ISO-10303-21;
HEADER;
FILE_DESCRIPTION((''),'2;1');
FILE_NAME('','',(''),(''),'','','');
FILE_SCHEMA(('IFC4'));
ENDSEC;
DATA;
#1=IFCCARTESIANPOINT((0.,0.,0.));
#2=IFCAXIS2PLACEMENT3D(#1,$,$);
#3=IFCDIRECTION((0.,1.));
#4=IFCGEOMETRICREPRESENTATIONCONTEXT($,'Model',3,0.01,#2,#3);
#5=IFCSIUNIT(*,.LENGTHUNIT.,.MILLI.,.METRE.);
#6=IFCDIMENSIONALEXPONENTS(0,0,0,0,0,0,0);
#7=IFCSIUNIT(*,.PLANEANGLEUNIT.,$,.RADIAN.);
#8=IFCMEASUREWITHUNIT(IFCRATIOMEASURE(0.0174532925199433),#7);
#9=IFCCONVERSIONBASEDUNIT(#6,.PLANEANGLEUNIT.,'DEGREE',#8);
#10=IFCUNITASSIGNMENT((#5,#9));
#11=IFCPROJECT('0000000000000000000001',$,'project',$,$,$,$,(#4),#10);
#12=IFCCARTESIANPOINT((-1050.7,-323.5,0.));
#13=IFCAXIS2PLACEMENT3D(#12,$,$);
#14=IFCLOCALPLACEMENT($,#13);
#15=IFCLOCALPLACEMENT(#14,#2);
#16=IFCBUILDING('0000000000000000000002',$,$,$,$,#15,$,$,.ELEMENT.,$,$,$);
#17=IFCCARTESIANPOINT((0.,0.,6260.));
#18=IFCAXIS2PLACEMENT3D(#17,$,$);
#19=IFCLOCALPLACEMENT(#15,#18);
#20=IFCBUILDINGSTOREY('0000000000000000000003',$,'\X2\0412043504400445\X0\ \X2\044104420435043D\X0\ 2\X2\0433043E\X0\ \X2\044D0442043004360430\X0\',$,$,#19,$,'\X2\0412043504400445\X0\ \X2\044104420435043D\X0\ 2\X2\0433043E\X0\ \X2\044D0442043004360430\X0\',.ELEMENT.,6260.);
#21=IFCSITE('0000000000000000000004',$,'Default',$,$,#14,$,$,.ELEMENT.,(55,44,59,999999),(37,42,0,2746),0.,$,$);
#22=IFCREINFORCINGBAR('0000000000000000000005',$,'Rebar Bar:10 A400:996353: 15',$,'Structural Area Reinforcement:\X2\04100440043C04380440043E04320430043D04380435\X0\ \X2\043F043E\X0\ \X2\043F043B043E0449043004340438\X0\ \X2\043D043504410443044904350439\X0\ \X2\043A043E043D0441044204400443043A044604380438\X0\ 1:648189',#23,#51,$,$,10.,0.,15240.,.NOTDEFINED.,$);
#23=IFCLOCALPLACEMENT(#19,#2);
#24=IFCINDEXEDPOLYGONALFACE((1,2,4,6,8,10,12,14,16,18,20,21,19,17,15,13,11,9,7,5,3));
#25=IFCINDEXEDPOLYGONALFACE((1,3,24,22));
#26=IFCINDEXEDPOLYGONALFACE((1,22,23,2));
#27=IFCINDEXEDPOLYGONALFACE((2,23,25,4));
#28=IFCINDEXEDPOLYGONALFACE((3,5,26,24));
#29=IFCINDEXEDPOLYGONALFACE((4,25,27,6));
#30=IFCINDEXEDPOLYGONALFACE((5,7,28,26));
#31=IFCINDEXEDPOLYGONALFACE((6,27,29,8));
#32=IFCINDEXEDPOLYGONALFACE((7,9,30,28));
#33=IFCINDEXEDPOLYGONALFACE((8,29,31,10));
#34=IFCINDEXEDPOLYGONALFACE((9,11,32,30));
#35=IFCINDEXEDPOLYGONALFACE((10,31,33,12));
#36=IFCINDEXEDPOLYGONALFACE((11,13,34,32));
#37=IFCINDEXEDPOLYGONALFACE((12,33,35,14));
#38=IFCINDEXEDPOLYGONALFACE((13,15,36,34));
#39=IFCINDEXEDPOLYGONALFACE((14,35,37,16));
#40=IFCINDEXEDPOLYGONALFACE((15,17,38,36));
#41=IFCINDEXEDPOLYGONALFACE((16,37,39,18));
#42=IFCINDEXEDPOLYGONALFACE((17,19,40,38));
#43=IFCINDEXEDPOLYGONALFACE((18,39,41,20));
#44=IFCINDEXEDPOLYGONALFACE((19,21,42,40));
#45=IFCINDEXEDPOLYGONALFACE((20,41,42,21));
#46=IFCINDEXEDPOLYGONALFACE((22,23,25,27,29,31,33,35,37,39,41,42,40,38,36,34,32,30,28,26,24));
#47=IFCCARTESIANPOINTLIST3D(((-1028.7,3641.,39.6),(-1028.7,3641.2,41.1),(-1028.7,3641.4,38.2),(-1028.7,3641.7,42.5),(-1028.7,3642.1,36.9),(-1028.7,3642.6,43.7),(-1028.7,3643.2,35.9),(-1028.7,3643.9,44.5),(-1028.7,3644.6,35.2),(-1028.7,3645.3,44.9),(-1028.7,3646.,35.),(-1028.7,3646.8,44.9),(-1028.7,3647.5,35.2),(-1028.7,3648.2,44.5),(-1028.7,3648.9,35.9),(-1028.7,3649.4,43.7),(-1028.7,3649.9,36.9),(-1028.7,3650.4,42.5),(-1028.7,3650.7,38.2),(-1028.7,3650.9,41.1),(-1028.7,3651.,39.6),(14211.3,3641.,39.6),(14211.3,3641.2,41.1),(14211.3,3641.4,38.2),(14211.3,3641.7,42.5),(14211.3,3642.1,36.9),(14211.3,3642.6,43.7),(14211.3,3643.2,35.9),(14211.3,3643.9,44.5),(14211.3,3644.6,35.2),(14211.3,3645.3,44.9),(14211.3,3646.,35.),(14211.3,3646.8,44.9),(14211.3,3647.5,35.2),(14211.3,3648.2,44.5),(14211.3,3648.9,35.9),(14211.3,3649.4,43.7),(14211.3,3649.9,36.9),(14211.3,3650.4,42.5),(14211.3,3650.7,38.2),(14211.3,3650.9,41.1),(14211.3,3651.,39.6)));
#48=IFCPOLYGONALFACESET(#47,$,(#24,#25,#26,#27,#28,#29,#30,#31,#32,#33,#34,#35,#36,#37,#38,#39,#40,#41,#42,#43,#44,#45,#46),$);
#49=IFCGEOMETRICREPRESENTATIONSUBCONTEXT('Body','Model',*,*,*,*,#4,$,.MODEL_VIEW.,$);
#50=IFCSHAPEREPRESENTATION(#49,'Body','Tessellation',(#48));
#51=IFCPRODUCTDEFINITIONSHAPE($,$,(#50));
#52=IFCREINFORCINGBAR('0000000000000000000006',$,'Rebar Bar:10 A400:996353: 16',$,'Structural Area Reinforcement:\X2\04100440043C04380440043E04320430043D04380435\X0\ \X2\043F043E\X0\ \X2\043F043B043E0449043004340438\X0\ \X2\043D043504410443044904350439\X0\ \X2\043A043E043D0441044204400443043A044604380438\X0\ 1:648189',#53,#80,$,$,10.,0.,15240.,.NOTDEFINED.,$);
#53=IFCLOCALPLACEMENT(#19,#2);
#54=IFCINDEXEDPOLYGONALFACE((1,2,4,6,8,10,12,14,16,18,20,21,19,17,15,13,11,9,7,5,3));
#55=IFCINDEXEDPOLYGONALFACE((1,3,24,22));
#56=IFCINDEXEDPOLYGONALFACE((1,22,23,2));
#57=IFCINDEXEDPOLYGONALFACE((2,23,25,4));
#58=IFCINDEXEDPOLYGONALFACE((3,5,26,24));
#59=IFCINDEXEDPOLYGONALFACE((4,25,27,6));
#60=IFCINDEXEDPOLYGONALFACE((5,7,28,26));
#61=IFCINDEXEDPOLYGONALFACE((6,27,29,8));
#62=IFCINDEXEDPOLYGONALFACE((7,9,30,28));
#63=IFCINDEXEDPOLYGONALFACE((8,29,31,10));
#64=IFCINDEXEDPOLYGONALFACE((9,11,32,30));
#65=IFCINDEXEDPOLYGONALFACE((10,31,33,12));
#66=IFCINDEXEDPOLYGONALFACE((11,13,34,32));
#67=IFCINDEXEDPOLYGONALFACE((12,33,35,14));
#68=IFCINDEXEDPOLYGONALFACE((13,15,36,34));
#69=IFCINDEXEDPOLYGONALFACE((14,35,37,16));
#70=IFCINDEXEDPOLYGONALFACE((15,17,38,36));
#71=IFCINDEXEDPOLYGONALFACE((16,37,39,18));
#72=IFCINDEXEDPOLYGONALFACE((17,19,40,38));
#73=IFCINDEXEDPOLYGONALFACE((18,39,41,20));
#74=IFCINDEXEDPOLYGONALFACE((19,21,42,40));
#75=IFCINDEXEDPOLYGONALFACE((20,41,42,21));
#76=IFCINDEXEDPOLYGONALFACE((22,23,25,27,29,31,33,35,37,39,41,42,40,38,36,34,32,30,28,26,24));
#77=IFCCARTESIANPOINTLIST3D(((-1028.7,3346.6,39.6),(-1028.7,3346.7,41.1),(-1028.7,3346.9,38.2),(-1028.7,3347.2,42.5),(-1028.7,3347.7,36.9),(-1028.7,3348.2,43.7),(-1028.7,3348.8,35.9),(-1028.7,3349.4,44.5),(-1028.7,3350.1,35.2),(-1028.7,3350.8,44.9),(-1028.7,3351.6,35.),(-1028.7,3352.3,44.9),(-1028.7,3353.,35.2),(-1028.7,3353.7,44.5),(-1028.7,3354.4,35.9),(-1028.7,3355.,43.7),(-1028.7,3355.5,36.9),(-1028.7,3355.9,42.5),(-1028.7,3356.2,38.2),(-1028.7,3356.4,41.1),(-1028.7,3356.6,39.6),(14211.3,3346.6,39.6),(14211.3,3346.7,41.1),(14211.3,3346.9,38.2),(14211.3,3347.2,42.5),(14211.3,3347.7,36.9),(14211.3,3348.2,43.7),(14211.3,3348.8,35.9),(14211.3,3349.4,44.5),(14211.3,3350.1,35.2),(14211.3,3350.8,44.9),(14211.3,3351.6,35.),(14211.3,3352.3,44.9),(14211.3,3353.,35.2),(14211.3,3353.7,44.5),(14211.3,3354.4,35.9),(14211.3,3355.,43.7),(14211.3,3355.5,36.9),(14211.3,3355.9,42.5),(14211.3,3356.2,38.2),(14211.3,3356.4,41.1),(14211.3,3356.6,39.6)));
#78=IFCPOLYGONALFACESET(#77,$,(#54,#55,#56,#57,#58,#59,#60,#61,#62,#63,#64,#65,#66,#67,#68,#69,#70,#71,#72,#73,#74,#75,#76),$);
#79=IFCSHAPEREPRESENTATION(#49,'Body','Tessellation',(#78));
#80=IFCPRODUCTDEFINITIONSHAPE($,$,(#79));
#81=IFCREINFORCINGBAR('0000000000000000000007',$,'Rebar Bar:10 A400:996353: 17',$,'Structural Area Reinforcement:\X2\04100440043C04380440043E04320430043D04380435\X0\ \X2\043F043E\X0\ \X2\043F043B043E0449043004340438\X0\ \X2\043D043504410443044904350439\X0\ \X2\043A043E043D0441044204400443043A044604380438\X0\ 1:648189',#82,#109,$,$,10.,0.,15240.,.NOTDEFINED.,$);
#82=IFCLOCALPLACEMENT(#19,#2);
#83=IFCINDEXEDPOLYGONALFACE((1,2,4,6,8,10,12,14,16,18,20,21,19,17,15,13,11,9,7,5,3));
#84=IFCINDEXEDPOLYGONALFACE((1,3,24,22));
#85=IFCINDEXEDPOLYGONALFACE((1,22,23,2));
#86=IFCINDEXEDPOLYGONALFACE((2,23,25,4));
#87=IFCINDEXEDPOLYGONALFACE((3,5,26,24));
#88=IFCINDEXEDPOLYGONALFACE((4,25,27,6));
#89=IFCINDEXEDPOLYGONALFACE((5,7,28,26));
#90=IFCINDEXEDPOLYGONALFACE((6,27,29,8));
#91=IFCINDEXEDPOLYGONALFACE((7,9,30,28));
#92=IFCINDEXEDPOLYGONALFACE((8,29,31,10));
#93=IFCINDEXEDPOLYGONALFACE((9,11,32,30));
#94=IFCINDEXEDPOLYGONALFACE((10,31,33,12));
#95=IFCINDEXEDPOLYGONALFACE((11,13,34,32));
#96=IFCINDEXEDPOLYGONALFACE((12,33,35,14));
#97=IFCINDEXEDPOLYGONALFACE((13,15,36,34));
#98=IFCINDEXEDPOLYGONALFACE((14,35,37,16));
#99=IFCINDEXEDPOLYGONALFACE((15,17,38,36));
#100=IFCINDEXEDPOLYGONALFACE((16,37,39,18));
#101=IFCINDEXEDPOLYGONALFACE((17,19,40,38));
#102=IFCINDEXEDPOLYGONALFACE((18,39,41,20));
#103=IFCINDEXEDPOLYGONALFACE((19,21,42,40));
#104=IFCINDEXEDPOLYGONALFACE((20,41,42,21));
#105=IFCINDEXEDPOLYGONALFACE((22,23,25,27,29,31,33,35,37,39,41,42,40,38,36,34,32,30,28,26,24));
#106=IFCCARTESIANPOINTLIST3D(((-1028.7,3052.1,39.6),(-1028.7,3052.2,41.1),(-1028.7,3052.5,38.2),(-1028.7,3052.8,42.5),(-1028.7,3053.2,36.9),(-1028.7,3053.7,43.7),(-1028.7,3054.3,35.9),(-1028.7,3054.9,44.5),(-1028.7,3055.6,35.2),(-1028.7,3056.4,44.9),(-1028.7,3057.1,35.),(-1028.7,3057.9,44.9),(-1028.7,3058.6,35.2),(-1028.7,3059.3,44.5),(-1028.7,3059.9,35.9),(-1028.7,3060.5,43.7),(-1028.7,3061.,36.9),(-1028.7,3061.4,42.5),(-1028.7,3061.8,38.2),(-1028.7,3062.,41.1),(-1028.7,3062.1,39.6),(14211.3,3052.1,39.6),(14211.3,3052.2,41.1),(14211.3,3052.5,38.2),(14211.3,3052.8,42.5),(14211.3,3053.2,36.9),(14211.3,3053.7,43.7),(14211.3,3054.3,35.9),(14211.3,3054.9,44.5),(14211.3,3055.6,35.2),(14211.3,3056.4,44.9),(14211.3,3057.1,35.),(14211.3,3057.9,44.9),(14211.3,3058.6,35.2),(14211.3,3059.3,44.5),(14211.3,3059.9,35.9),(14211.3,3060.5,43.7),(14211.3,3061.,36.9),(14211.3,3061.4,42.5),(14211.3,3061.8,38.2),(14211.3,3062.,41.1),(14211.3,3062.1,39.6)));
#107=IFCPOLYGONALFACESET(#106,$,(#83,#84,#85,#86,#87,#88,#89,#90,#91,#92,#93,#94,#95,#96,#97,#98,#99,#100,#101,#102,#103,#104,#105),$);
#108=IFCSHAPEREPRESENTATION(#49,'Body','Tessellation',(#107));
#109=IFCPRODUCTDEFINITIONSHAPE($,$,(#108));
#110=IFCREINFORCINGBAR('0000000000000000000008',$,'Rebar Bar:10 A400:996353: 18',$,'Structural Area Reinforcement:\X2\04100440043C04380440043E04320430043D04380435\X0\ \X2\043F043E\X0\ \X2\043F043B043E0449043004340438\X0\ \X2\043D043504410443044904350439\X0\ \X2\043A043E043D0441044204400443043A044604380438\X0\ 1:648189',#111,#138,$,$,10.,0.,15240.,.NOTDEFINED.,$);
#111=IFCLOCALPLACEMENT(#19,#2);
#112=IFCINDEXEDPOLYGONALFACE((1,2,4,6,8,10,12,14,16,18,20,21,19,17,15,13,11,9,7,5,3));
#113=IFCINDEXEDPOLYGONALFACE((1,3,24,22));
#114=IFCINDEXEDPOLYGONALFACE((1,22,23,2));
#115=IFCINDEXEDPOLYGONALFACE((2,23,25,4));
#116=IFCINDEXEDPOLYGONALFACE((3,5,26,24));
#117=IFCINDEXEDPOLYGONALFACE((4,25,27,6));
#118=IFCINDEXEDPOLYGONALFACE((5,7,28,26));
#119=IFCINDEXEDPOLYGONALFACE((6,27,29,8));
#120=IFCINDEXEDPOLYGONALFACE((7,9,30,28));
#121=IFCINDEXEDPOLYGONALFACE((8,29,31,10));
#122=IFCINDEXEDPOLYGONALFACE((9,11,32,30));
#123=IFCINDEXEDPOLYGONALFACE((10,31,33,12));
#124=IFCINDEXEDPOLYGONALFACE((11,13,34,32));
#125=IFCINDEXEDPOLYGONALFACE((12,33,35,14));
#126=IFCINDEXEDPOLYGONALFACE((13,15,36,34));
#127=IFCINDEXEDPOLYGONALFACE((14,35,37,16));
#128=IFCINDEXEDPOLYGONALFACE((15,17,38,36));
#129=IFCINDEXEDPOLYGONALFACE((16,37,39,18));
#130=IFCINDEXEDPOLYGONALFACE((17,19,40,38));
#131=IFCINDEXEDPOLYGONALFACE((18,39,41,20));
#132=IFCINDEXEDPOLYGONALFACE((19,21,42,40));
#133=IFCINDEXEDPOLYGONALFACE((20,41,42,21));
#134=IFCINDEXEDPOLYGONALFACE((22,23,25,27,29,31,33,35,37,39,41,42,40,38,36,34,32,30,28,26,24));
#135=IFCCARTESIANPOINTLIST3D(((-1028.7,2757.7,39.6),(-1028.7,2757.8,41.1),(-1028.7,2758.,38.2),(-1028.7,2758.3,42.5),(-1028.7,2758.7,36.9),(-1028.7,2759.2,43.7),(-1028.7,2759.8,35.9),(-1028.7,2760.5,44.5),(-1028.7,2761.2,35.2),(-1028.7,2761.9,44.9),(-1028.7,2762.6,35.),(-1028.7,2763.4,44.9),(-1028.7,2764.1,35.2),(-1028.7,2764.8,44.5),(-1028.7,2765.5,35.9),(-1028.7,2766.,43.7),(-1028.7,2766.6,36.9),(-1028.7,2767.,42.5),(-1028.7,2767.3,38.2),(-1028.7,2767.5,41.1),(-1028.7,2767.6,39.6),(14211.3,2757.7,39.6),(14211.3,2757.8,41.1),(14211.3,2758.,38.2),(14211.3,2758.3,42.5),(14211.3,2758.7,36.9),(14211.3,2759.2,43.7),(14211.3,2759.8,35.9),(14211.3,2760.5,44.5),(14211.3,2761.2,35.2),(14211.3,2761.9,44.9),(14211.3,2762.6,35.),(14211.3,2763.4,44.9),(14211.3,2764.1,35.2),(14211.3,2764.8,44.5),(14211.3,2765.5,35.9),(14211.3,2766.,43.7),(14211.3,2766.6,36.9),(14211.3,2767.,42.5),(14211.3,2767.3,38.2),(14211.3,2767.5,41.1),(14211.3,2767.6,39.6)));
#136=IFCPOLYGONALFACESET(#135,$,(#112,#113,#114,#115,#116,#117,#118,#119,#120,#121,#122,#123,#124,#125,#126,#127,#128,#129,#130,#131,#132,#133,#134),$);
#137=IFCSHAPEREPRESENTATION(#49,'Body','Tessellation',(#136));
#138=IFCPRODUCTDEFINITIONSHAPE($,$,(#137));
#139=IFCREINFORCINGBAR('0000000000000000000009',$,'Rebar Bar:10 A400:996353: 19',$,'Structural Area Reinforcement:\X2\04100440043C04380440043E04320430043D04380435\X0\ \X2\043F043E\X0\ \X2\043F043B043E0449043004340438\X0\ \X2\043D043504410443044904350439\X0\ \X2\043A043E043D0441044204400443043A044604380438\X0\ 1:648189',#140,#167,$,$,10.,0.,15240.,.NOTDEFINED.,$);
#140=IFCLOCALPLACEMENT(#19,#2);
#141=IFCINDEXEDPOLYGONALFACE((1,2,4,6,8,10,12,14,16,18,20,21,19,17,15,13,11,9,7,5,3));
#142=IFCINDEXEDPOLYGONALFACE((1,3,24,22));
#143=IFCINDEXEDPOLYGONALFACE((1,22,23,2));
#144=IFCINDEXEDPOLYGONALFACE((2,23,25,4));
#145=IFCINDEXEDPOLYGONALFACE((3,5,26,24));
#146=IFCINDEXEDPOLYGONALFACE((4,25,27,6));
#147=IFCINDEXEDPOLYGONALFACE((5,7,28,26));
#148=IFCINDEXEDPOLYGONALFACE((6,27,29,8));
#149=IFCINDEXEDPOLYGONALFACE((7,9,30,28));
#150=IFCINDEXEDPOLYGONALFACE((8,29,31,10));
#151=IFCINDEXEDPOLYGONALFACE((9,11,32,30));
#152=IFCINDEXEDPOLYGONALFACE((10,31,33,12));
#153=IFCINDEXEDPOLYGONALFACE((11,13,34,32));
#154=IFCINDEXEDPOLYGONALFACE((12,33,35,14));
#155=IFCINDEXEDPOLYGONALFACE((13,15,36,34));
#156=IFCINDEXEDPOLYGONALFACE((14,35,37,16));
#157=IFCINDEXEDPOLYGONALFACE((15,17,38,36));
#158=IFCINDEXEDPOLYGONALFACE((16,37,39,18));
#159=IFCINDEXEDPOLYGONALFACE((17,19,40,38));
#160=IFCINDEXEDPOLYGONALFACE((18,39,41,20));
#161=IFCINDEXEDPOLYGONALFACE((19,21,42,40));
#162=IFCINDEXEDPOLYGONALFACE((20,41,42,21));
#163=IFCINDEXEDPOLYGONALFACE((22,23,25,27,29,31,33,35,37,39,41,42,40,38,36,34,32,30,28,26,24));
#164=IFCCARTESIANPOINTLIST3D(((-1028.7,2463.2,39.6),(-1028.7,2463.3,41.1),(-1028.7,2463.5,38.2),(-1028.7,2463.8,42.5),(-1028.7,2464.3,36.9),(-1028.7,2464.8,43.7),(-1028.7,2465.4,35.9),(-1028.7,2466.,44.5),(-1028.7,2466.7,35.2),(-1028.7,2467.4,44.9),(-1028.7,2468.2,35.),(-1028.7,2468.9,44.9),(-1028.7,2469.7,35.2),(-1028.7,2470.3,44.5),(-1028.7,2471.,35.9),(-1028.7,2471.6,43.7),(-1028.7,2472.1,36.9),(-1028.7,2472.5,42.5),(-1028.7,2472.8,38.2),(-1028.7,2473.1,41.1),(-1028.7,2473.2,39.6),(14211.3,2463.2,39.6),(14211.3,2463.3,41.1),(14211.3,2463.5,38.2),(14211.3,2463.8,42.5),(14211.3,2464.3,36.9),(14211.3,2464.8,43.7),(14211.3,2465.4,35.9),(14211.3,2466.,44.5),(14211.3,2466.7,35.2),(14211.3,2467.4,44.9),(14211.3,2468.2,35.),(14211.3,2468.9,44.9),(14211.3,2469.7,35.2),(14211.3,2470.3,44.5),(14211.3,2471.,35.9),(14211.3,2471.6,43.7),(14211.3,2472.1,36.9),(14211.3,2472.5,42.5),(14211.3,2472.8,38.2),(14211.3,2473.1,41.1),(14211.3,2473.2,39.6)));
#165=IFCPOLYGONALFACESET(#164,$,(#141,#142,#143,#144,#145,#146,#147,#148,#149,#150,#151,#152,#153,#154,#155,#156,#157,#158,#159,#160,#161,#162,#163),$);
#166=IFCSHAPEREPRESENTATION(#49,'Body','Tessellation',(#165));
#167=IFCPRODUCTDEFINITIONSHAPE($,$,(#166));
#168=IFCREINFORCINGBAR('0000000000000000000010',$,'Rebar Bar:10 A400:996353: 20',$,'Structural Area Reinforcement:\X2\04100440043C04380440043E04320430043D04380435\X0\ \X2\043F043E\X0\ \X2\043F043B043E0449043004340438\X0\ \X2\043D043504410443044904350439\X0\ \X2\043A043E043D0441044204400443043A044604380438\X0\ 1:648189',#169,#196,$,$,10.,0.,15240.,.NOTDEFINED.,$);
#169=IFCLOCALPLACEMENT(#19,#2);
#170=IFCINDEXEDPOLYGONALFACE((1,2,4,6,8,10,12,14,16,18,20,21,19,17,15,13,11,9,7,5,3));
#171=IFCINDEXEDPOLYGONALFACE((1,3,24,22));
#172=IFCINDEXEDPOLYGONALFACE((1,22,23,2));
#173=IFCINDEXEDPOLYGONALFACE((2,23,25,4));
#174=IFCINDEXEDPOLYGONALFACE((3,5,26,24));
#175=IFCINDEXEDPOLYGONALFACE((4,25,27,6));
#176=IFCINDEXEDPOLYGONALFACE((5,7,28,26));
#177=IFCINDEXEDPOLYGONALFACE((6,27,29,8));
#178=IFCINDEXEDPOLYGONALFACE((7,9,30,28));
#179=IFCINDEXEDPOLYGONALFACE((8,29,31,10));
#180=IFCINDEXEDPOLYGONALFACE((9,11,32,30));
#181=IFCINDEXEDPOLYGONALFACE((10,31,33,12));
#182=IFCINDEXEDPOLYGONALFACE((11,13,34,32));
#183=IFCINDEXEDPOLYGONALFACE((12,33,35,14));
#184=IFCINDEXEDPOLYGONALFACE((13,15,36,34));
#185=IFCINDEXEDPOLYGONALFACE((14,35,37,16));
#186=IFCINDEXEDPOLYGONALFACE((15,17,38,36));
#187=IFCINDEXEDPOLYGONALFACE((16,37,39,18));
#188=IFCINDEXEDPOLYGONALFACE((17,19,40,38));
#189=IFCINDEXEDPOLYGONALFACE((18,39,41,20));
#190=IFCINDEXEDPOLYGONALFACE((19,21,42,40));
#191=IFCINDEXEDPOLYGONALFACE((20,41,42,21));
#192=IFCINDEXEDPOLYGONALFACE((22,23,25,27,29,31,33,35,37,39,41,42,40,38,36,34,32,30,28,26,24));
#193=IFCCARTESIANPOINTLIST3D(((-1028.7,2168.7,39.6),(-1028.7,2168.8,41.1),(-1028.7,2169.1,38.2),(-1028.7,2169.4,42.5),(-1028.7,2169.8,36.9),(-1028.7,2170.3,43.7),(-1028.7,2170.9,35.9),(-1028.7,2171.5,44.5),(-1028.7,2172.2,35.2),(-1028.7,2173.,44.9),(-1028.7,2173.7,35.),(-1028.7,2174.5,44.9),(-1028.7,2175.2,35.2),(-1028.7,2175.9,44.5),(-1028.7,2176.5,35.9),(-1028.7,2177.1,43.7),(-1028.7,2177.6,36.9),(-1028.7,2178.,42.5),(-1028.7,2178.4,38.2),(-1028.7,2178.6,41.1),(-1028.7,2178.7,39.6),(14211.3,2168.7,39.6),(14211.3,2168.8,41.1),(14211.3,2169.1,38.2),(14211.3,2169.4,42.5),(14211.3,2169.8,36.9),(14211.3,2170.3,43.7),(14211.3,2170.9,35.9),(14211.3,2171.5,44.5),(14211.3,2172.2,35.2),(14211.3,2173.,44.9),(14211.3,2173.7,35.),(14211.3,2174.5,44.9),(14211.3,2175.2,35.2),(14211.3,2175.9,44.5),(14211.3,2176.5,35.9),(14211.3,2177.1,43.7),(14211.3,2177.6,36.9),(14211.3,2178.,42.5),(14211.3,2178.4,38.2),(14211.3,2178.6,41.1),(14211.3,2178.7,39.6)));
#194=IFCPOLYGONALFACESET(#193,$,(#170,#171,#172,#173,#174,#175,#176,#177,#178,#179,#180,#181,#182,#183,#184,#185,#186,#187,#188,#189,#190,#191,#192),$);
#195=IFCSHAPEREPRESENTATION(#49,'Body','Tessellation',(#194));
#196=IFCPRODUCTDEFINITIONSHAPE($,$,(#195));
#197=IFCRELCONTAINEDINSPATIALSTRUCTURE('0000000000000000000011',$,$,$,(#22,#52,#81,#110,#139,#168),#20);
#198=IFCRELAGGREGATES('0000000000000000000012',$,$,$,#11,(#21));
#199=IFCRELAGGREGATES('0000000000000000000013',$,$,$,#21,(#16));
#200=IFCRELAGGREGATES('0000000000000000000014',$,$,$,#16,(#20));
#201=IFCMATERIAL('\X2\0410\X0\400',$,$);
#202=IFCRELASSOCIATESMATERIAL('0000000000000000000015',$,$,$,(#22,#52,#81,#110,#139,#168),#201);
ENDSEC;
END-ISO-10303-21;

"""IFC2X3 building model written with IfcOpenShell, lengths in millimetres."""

from ifc_helpers import new_model, entity, si_unit, converted_unit, direction, frame, origin, place, context, subcontext, project, spatial, material, element, save


model = new_model("IFC2X3")

# Units and contexts
model_context = context("Model", 3, precision=0.01, world=origin(), true_north=direction((0.0, 1.0)))
body_context = subcontext(model_context, "Body", "Model", "MODEL_VIEW")
ifc_project = project(units=[si_unit("LENGTHUNIT", "METRE", prefix="MILLI"), converted_unit("PLANEANGLEUNIT", "DEGREE", entity("IfcRatioMeasure", 0.0174532925199433), si_unit("PLANEANGLEUNIT", "RADIAN"), dimensions=[0, 0, 0, 0, 0, 0, 0])], contexts=[model_context])

# Site, building, storey
site_placement = place(None, frame((-1050.7, -323.5, 0.0)))
site = spatial("IfcSite", under=ifc_project, at=site_placement, Name="Default", CompositionType="ELEMENT", RefLatitude=(55, 44, 59, 999999), RefLongitude=(37, 42, 0, 2746), RefElevation=0.0)
building_placement = place(site_placement, origin())
building = spatial("IfcBuilding", under=site, at=building_placement, CompositionType="ELEMENT")
storey_placement = place(building_placement, frame((0.0, 0.0, 6260.0)))
storey = spatial("IfcBuildingStorey", under=building, at=storey_placement, Name="Верх стен 2го этажа", LongName="Верх стен 2го этажа", CompositionType="ELEMENT", Elevation=6260.0)

# Reinforcing bars
ifc_material = material(Name="А400")
reinforcing_bar_1_placement = place(storey_placement, origin())
element("IfcReinforcingBar", 1, at=reinforcing_bar_1_placement, inside=storey, material=ifc_material, Name="Rebar Bar:10 A400:996353: 15", ObjectType="Structural Area Reinforcement:Армирование по площади несущей конструкции 1:648189", BarLength=15240.0, BarRole="NOTDEFINED", CrossSectionArea=0.0, NominalDiameter=10.0, context=body_context, shape_type="AdvancedSweptSolid", body=[
    entity("IfcSweptDiskSolid", entity("IfcCompositeCurve", [entity("IfcCompositeCurveSegment", "CONTINUOUS", True, entity("IfcPolyline", [entity("IfcCartesianPoint", [14211.3, 3646.0, 40.0]), entity("IfcCartesianPoint", [-1028.7, 3646.0, 40.0])]))], False), 5.0, None, 0.0, 1.0),
])
reinforcing_bar_2_placement = place(storey_placement, origin())
element("IfcReinforcingBar", 2, at=reinforcing_bar_2_placement, inside=storey, material=ifc_material, Name="Rebar Bar:10 A400:996353: 16", ObjectType="Structural Area Reinforcement:Армирование по площади несущей конструкции 1:648189", BarLength=15240.0, BarRole="NOTDEFINED", CrossSectionArea=0.0, NominalDiameter=10.0, context=body_context, shape_type="AdvancedSweptSolid", body=[
    entity("IfcSweptDiskSolid", entity("IfcCompositeCurve", [entity("IfcCompositeCurveSegment", "CONTINUOUS", True, entity("IfcPolyline", [entity("IfcCartesianPoint", [14211.3, 3351.6, 40.0]), entity("IfcCartesianPoint", [-1028.7, 3351.6, 40.0])]))], False), 5.0, None, 0.0, 1.0),
])
reinforcing_bar_3_placement = place(storey_placement, origin())
element("IfcReinforcingBar", 3, at=reinforcing_bar_3_placement, inside=storey, material=ifc_material, Name="Rebar Bar:10 A400:996353: 17", ObjectType="Structural Area Reinforcement:Армирование по площади несущей конструкции 1:648189", BarLength=15240.0, BarRole="NOTDEFINED", CrossSectionArea=0.0, NominalDiameter=10.0, context=body_context, shape_type="AdvancedSweptSolid", body=[
    entity("IfcSweptDiskSolid", entity("IfcCompositeCurve", [entity("IfcCompositeCurveSegment", "CONTINUOUS", True, entity("IfcPolyline", [entity("IfcCartesianPoint", [14211.3, 3057.1, 40.0]), entity("IfcCartesianPoint", [-1028.7, 3057.1, 40.0])]))], False), 5.0, None, 0.0, 1.0),
])
reinforcing_bar_4_placement = place(storey_placement, origin())
element("IfcReinforcingBar", 4, at=reinforcing_bar_4_placement, inside=storey, material=ifc_material, Name="Rebar Bar:10 A400:996353: 18", ObjectType="Structural Area Reinforcement:Армирование по площади несущей конструкции 1:648189", BarLength=15240.0, BarRole="NOTDEFINED", CrossSectionArea=0.0, NominalDiameter=10.0, context=body_context, shape_type="AdvancedSweptSolid", body=[
    entity("IfcSweptDiskSolid", entity("IfcCompositeCurve", [entity("IfcCompositeCurveSegment", "CONTINUOUS", True, entity("IfcPolyline", [entity("IfcCartesianPoint", [14211.3, 2762.6, 40.0]), entity("IfcCartesianPoint", [-1028.7, 2762.6, 40.0])]))], False), 5.0, None, 0.0, 1.0),
])
reinforcing_bar_5_placement = place(storey_placement, origin())
element("IfcReinforcingBar", 5, at=reinforcing_bar_5_placement, inside=storey, material=ifc_material, Name="Rebar Bar:10 A400:996353: 19", ObjectType="Structural Area Reinforcement:Армирование по площади несущей конструкции 1:648189", BarLength=15240.0, BarRole="NOTDEFINED", CrossSectionArea=0.0, NominalDiameter=10.0, context=body_context, shape_type="AdvancedSweptSolid", body=[
    entity("IfcSweptDiskSolid", entity("IfcCompositeCurve", [entity("IfcCompositeCurveSegment", "CONTINUOUS", True, entity("IfcPolyline", [entity("IfcCartesianPoint", [14211.3, 2468.2, 40.0]), entity("IfcCartesianPoint", [-1028.7, 2468.2, 40.0])]))], False), 5.0, None, 0.0, 1.0),
])
reinforcing_bar_6_placement = place(storey_placement, origin())
element("IfcReinforcingBar", 6, at=reinforcing_bar_6_placement, inside=storey, material=ifc_material, Name="Rebar Bar:10 A400:996353: 20", ObjectType="Structural Area Reinforcement:Армирование по площади несущей конструкции 1:648189", BarLength=15240.0, BarRole="NOTDEFINED", CrossSectionArea=0.0, NominalDiameter=10.0, context=body_context, shape_type="AdvancedSweptSolid", body=[
    entity("IfcSweptDiskSolid", entity("IfcCompositeCurve", [entity("IfcCompositeCurveSegment", "CONTINUOUS", True, entity("IfcPolyline", [entity("IfcCartesianPoint", [14211.3, 2173.7, 40.0]), entity("IfcCartesianPoint", [-1028.7, 2173.7, 40.0])]))], False), 5.0, None, 0.0, 1.0),
])

save(model, "model.ifc")
